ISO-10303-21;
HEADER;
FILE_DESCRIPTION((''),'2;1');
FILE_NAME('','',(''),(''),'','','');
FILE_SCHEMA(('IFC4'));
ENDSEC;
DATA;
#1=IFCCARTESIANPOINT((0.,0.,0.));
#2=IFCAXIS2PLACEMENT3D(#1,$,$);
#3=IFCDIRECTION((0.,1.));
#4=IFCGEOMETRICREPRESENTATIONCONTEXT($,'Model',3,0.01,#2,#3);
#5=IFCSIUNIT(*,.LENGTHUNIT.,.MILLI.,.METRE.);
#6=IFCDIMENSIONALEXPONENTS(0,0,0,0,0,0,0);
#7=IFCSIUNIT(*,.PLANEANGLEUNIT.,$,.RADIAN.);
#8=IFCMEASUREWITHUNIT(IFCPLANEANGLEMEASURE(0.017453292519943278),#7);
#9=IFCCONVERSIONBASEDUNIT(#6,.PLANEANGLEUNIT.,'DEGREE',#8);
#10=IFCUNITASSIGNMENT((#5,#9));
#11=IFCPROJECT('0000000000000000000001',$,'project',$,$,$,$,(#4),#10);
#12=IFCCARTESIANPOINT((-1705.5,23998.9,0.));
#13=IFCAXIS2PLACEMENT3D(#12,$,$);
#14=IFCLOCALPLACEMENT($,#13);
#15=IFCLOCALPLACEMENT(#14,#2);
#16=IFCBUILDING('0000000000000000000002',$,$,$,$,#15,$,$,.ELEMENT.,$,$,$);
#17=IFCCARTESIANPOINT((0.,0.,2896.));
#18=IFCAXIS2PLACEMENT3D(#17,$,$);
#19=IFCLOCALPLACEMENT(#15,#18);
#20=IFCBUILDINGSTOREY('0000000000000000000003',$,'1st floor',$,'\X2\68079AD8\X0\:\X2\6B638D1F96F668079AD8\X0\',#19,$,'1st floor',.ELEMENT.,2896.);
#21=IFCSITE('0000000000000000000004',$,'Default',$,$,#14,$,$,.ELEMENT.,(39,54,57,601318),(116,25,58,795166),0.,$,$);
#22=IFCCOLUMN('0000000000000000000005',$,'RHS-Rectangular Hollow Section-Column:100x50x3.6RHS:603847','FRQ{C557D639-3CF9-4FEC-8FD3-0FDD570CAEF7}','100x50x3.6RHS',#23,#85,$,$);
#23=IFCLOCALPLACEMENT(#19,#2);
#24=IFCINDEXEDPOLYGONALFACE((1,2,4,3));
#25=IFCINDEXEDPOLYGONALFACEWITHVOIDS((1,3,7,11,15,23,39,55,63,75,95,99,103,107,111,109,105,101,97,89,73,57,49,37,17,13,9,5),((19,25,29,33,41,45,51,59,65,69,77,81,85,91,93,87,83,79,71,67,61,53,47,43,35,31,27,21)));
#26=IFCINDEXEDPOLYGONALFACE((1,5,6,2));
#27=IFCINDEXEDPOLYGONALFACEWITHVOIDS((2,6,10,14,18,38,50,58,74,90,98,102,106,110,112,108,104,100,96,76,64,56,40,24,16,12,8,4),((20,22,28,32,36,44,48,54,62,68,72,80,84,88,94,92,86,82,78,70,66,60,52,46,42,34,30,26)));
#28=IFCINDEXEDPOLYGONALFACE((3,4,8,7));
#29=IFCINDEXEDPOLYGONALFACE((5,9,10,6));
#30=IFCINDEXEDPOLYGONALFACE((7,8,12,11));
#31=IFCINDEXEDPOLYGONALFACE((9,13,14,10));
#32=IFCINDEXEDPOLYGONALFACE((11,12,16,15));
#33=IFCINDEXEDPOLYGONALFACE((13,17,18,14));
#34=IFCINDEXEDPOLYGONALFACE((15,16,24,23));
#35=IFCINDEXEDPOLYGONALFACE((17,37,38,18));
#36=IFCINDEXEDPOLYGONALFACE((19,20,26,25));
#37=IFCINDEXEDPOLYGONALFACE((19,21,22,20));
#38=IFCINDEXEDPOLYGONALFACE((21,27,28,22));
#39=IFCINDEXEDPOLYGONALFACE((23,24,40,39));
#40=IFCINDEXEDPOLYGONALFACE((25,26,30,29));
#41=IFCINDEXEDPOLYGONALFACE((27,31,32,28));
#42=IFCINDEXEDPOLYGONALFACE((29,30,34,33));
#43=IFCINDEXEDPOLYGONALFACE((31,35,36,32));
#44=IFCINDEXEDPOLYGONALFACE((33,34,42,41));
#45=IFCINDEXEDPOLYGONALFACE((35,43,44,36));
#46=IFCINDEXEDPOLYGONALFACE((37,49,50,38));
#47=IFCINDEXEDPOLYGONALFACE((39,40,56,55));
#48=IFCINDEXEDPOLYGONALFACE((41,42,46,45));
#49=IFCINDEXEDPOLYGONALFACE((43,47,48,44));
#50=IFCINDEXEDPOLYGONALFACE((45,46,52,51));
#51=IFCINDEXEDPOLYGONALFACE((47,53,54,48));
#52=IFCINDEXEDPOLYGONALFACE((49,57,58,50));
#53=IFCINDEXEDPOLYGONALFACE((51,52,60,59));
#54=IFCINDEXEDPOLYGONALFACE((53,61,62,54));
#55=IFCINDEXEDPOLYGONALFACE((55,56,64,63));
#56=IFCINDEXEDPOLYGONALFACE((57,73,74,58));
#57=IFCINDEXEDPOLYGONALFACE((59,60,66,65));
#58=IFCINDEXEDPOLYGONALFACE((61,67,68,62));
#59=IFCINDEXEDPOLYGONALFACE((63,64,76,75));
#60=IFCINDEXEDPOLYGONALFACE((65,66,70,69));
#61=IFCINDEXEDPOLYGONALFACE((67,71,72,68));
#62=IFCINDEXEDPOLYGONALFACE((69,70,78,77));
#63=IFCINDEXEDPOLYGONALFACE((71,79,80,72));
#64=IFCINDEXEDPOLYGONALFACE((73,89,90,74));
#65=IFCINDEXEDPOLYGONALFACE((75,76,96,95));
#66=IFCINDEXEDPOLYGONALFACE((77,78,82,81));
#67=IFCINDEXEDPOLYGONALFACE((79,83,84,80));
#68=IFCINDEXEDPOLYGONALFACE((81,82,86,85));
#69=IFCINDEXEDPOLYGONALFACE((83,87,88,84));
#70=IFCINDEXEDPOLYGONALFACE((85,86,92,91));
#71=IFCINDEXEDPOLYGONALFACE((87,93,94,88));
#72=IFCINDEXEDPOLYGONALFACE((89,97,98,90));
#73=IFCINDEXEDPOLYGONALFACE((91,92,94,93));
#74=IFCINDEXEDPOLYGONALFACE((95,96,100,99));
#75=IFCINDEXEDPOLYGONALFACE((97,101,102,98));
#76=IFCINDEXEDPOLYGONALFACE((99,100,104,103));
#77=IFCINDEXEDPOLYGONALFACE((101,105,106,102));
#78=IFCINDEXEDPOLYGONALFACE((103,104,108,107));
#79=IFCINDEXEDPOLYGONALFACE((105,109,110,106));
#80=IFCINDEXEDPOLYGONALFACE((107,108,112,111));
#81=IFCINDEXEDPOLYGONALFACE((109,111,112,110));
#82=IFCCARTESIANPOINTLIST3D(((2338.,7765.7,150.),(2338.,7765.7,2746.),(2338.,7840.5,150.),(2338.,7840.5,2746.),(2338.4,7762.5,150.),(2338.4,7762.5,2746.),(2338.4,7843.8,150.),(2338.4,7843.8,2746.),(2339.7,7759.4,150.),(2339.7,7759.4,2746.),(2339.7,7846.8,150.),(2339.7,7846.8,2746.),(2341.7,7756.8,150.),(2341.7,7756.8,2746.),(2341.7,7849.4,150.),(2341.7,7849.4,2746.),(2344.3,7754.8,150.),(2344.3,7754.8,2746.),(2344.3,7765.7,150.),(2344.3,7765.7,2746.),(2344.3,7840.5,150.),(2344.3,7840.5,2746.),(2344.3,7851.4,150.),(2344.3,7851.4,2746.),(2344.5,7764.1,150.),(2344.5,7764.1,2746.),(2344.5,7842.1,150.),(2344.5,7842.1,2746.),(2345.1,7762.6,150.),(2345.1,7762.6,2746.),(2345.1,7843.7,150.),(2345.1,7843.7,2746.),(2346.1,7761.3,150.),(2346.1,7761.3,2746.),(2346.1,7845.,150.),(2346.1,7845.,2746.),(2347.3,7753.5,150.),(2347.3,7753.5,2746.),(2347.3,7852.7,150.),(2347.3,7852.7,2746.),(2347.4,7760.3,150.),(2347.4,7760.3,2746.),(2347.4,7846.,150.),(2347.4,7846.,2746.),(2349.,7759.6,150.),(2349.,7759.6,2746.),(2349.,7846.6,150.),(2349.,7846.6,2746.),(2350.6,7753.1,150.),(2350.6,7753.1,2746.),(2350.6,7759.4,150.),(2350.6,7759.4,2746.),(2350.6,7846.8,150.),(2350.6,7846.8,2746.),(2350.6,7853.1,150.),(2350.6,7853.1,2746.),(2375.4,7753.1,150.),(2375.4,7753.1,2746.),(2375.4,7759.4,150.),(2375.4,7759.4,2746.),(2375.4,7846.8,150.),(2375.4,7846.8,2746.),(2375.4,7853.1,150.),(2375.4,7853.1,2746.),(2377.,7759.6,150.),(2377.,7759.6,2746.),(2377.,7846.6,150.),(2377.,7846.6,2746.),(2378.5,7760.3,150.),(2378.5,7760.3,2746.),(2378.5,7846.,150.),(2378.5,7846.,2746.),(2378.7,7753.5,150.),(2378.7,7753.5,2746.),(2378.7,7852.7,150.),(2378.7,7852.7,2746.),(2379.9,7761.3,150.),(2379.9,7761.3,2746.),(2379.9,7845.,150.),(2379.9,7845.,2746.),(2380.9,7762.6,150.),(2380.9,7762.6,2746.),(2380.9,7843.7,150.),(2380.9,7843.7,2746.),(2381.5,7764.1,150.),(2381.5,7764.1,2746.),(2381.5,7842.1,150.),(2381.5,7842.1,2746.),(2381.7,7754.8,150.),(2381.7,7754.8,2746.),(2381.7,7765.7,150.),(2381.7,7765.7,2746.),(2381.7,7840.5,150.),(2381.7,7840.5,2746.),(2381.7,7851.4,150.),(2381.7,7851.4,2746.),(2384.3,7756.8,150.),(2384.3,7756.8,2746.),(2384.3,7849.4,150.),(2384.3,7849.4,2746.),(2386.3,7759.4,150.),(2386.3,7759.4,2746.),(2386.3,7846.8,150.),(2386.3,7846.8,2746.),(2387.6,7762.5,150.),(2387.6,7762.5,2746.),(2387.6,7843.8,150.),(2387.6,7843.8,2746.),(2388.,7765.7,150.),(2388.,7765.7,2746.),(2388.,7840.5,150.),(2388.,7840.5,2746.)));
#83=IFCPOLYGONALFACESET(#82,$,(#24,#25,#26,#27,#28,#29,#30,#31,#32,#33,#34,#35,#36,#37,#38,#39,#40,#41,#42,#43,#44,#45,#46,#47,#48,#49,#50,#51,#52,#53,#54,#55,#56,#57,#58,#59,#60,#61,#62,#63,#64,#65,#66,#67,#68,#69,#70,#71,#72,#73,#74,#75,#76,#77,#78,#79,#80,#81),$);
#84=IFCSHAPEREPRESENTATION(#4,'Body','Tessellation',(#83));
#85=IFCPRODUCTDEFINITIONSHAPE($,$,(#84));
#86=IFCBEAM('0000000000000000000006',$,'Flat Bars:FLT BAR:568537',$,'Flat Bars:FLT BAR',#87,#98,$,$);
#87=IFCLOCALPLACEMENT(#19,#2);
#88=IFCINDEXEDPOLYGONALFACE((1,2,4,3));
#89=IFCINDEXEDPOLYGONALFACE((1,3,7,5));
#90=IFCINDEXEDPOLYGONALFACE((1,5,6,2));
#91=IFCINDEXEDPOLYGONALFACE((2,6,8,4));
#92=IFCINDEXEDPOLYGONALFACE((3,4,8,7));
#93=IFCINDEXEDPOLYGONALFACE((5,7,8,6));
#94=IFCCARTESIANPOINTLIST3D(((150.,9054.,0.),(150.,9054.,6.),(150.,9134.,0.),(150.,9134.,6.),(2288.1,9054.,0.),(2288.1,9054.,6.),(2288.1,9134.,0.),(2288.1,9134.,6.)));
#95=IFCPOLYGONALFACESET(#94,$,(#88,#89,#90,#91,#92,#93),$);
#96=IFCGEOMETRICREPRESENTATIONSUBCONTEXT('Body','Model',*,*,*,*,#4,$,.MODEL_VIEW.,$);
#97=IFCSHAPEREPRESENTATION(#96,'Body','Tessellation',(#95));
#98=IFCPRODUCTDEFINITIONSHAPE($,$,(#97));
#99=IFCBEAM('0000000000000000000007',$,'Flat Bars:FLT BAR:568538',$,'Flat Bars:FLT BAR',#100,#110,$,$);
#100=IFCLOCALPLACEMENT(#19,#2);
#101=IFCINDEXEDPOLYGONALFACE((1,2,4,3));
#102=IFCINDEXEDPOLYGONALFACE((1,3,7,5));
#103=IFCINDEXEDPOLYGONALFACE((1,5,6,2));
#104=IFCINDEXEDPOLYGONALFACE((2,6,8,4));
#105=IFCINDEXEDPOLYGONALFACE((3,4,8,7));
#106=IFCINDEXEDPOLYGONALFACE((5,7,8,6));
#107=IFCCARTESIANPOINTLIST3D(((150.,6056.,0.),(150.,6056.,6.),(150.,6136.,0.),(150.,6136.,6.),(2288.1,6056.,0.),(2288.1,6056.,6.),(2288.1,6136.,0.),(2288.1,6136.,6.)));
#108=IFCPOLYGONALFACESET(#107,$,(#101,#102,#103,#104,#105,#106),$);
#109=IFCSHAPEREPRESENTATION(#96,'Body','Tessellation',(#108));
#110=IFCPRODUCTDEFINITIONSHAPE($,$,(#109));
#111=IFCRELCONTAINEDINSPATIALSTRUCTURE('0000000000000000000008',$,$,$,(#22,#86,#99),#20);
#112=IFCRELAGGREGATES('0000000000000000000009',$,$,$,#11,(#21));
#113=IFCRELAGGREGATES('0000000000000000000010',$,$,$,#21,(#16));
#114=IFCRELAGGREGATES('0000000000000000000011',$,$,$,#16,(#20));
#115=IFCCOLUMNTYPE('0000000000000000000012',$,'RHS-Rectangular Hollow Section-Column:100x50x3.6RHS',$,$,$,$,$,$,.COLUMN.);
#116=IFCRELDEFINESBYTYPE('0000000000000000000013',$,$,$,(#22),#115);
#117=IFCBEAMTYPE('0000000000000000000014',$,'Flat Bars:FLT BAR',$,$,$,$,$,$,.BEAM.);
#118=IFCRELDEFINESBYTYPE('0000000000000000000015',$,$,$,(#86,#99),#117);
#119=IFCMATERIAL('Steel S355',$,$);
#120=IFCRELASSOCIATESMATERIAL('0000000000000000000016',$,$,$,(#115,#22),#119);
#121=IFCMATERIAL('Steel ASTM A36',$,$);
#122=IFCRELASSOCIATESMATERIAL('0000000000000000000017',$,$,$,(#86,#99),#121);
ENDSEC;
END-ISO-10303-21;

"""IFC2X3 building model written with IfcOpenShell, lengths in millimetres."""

from ifc_helpers import new_model, entity, si_unit, converted_unit, direction, frame, origin, origin_2d, origin_2d_with_axis, place, context, subcontext, project, spatial, rectangle, hollow_rectangle, extrude, clip, halfspace, material, type_object, element, save


model = new_model("IFC2X3")

# Units and contexts
model_context = context("Model", 3, precision=0.01, world=origin(), true_north=direction((0.0, 1.0)))
body_context = subcontext(model_context, "Body", "Model", "MODEL_VIEW")
ifc_project = project(units=[si_unit("LENGTHUNIT", "METRE", prefix="MILLI"), converted_unit("PLANEANGLEUNIT", "DEGREE", entity("IfcPlaneAngleMeasure", 0.017453292519943278), si_unit("PLANEANGLEUNIT", "RADIAN"), dimensions=[0, 0, 0, 0, 0, 0, 0])], contexts=[model_context])

# Site, building, storey
site_placement = place(None, frame((-1705.5, 23998.9, 0.0)))
site = spatial("IfcSite", under=ifc_project, at=site_placement, Name="Default", CompositionType="ELEMENT", RefLatitude=(39, 54, 57, 601318), RefLongitude=(116, 25, 58, 795166), RefElevation=0.0)
building_placement = place(site_placement, origin())
building = spatial("IfcBuilding", under=site, at=building_placement, CompositionType="ELEMENT")
storey_placement = place(building_placement, frame((0.0, 0.0, 2896.0)))
storey = spatial("IfcBuildingStorey", under=building, at=storey_placement, Name="1st floor", ObjectType="标高:正负零标高", LongName="1st floor", CompositionType="ELEMENT", Elevation=2896.0)

# Shared definitions
ifc_material_1 = material(Name="Steel S355")
column_type = type_object("IfcColumnType", Name="RHS-Rectangular Hollow Section-Column:100x50x3.6RHS", PredefinedType="COLUMN", material=ifc_material_1)

# Column
column_1_placement = place(storey_placement, frame((2363.0, 7803.1, 2746.0), z_axis=(0.0, 0.0, 1.0), x_axis=(-1.0, 0.0, 0.0)))
element("IfcColumn", 1, at=column_1_placement, inside=storey, type_object=column_type, material=ifc_material_1, Name="RHS-Rectangular Hollow Section-Column:100x50x3.6RHS:603847", Description="FRQ{C557D639-3CF9-4FEC-8FD3-0FDD570CAEF7}", ObjectType="100x50x3.6RHS", context=model_context, shape_type="Clipping", body=[
    clip(extrude(hollow_rectangle(XDim=50.0, YDim=100.0, WallThickness=6.3, InnerFilletRadius=6.3, OuterFilletRadius=12.6, at=origin_2d()), origin(), (0.0, 0.0, -1.0), 2651.9), halfspace(frame((2363.0, 7803.1, -2596.0), z_axis=(0.0, 0.0, 1.0), x_axis=(-1.0, 0.0, 0.0)), True)),
])

# Beams
ifc_material_2 = material(Name="Steel ASTM A36")
beam_type = type_object("IfcBeamType", Name="Flat Bars:FLT BAR", PredefinedType="BEAM")
for number, where, name in (
    (2, (150.0, 9094.0, 6.0), "Flat Bars:FLT BAR:568537"),
    (3, (150.0, 6096.0, 6.0), "Flat Bars:FLT BAR:568538"),
):
    element("IfcBeam", number, at=place(storey_placement, frame(where)), inside=storey, type_object=beam_type, material=ifc_material_2, Name=name, ObjectType="Flat Bars:FLT BAR", context=body_context, shape_type="SweptSolid", body=[
        extrude(rectangle(XDim=6.0, YDim=80.0, at=origin_2d_with_axis()), frame((0.0, 0.0, -3.0), z_axis=(1.0, 0.0, 0.0), x_axis=(0.0, 0.0, -1.0)), (0.0, 0.0, 1.0), 2138.1),
    ])

save(model, "model.ifc")
